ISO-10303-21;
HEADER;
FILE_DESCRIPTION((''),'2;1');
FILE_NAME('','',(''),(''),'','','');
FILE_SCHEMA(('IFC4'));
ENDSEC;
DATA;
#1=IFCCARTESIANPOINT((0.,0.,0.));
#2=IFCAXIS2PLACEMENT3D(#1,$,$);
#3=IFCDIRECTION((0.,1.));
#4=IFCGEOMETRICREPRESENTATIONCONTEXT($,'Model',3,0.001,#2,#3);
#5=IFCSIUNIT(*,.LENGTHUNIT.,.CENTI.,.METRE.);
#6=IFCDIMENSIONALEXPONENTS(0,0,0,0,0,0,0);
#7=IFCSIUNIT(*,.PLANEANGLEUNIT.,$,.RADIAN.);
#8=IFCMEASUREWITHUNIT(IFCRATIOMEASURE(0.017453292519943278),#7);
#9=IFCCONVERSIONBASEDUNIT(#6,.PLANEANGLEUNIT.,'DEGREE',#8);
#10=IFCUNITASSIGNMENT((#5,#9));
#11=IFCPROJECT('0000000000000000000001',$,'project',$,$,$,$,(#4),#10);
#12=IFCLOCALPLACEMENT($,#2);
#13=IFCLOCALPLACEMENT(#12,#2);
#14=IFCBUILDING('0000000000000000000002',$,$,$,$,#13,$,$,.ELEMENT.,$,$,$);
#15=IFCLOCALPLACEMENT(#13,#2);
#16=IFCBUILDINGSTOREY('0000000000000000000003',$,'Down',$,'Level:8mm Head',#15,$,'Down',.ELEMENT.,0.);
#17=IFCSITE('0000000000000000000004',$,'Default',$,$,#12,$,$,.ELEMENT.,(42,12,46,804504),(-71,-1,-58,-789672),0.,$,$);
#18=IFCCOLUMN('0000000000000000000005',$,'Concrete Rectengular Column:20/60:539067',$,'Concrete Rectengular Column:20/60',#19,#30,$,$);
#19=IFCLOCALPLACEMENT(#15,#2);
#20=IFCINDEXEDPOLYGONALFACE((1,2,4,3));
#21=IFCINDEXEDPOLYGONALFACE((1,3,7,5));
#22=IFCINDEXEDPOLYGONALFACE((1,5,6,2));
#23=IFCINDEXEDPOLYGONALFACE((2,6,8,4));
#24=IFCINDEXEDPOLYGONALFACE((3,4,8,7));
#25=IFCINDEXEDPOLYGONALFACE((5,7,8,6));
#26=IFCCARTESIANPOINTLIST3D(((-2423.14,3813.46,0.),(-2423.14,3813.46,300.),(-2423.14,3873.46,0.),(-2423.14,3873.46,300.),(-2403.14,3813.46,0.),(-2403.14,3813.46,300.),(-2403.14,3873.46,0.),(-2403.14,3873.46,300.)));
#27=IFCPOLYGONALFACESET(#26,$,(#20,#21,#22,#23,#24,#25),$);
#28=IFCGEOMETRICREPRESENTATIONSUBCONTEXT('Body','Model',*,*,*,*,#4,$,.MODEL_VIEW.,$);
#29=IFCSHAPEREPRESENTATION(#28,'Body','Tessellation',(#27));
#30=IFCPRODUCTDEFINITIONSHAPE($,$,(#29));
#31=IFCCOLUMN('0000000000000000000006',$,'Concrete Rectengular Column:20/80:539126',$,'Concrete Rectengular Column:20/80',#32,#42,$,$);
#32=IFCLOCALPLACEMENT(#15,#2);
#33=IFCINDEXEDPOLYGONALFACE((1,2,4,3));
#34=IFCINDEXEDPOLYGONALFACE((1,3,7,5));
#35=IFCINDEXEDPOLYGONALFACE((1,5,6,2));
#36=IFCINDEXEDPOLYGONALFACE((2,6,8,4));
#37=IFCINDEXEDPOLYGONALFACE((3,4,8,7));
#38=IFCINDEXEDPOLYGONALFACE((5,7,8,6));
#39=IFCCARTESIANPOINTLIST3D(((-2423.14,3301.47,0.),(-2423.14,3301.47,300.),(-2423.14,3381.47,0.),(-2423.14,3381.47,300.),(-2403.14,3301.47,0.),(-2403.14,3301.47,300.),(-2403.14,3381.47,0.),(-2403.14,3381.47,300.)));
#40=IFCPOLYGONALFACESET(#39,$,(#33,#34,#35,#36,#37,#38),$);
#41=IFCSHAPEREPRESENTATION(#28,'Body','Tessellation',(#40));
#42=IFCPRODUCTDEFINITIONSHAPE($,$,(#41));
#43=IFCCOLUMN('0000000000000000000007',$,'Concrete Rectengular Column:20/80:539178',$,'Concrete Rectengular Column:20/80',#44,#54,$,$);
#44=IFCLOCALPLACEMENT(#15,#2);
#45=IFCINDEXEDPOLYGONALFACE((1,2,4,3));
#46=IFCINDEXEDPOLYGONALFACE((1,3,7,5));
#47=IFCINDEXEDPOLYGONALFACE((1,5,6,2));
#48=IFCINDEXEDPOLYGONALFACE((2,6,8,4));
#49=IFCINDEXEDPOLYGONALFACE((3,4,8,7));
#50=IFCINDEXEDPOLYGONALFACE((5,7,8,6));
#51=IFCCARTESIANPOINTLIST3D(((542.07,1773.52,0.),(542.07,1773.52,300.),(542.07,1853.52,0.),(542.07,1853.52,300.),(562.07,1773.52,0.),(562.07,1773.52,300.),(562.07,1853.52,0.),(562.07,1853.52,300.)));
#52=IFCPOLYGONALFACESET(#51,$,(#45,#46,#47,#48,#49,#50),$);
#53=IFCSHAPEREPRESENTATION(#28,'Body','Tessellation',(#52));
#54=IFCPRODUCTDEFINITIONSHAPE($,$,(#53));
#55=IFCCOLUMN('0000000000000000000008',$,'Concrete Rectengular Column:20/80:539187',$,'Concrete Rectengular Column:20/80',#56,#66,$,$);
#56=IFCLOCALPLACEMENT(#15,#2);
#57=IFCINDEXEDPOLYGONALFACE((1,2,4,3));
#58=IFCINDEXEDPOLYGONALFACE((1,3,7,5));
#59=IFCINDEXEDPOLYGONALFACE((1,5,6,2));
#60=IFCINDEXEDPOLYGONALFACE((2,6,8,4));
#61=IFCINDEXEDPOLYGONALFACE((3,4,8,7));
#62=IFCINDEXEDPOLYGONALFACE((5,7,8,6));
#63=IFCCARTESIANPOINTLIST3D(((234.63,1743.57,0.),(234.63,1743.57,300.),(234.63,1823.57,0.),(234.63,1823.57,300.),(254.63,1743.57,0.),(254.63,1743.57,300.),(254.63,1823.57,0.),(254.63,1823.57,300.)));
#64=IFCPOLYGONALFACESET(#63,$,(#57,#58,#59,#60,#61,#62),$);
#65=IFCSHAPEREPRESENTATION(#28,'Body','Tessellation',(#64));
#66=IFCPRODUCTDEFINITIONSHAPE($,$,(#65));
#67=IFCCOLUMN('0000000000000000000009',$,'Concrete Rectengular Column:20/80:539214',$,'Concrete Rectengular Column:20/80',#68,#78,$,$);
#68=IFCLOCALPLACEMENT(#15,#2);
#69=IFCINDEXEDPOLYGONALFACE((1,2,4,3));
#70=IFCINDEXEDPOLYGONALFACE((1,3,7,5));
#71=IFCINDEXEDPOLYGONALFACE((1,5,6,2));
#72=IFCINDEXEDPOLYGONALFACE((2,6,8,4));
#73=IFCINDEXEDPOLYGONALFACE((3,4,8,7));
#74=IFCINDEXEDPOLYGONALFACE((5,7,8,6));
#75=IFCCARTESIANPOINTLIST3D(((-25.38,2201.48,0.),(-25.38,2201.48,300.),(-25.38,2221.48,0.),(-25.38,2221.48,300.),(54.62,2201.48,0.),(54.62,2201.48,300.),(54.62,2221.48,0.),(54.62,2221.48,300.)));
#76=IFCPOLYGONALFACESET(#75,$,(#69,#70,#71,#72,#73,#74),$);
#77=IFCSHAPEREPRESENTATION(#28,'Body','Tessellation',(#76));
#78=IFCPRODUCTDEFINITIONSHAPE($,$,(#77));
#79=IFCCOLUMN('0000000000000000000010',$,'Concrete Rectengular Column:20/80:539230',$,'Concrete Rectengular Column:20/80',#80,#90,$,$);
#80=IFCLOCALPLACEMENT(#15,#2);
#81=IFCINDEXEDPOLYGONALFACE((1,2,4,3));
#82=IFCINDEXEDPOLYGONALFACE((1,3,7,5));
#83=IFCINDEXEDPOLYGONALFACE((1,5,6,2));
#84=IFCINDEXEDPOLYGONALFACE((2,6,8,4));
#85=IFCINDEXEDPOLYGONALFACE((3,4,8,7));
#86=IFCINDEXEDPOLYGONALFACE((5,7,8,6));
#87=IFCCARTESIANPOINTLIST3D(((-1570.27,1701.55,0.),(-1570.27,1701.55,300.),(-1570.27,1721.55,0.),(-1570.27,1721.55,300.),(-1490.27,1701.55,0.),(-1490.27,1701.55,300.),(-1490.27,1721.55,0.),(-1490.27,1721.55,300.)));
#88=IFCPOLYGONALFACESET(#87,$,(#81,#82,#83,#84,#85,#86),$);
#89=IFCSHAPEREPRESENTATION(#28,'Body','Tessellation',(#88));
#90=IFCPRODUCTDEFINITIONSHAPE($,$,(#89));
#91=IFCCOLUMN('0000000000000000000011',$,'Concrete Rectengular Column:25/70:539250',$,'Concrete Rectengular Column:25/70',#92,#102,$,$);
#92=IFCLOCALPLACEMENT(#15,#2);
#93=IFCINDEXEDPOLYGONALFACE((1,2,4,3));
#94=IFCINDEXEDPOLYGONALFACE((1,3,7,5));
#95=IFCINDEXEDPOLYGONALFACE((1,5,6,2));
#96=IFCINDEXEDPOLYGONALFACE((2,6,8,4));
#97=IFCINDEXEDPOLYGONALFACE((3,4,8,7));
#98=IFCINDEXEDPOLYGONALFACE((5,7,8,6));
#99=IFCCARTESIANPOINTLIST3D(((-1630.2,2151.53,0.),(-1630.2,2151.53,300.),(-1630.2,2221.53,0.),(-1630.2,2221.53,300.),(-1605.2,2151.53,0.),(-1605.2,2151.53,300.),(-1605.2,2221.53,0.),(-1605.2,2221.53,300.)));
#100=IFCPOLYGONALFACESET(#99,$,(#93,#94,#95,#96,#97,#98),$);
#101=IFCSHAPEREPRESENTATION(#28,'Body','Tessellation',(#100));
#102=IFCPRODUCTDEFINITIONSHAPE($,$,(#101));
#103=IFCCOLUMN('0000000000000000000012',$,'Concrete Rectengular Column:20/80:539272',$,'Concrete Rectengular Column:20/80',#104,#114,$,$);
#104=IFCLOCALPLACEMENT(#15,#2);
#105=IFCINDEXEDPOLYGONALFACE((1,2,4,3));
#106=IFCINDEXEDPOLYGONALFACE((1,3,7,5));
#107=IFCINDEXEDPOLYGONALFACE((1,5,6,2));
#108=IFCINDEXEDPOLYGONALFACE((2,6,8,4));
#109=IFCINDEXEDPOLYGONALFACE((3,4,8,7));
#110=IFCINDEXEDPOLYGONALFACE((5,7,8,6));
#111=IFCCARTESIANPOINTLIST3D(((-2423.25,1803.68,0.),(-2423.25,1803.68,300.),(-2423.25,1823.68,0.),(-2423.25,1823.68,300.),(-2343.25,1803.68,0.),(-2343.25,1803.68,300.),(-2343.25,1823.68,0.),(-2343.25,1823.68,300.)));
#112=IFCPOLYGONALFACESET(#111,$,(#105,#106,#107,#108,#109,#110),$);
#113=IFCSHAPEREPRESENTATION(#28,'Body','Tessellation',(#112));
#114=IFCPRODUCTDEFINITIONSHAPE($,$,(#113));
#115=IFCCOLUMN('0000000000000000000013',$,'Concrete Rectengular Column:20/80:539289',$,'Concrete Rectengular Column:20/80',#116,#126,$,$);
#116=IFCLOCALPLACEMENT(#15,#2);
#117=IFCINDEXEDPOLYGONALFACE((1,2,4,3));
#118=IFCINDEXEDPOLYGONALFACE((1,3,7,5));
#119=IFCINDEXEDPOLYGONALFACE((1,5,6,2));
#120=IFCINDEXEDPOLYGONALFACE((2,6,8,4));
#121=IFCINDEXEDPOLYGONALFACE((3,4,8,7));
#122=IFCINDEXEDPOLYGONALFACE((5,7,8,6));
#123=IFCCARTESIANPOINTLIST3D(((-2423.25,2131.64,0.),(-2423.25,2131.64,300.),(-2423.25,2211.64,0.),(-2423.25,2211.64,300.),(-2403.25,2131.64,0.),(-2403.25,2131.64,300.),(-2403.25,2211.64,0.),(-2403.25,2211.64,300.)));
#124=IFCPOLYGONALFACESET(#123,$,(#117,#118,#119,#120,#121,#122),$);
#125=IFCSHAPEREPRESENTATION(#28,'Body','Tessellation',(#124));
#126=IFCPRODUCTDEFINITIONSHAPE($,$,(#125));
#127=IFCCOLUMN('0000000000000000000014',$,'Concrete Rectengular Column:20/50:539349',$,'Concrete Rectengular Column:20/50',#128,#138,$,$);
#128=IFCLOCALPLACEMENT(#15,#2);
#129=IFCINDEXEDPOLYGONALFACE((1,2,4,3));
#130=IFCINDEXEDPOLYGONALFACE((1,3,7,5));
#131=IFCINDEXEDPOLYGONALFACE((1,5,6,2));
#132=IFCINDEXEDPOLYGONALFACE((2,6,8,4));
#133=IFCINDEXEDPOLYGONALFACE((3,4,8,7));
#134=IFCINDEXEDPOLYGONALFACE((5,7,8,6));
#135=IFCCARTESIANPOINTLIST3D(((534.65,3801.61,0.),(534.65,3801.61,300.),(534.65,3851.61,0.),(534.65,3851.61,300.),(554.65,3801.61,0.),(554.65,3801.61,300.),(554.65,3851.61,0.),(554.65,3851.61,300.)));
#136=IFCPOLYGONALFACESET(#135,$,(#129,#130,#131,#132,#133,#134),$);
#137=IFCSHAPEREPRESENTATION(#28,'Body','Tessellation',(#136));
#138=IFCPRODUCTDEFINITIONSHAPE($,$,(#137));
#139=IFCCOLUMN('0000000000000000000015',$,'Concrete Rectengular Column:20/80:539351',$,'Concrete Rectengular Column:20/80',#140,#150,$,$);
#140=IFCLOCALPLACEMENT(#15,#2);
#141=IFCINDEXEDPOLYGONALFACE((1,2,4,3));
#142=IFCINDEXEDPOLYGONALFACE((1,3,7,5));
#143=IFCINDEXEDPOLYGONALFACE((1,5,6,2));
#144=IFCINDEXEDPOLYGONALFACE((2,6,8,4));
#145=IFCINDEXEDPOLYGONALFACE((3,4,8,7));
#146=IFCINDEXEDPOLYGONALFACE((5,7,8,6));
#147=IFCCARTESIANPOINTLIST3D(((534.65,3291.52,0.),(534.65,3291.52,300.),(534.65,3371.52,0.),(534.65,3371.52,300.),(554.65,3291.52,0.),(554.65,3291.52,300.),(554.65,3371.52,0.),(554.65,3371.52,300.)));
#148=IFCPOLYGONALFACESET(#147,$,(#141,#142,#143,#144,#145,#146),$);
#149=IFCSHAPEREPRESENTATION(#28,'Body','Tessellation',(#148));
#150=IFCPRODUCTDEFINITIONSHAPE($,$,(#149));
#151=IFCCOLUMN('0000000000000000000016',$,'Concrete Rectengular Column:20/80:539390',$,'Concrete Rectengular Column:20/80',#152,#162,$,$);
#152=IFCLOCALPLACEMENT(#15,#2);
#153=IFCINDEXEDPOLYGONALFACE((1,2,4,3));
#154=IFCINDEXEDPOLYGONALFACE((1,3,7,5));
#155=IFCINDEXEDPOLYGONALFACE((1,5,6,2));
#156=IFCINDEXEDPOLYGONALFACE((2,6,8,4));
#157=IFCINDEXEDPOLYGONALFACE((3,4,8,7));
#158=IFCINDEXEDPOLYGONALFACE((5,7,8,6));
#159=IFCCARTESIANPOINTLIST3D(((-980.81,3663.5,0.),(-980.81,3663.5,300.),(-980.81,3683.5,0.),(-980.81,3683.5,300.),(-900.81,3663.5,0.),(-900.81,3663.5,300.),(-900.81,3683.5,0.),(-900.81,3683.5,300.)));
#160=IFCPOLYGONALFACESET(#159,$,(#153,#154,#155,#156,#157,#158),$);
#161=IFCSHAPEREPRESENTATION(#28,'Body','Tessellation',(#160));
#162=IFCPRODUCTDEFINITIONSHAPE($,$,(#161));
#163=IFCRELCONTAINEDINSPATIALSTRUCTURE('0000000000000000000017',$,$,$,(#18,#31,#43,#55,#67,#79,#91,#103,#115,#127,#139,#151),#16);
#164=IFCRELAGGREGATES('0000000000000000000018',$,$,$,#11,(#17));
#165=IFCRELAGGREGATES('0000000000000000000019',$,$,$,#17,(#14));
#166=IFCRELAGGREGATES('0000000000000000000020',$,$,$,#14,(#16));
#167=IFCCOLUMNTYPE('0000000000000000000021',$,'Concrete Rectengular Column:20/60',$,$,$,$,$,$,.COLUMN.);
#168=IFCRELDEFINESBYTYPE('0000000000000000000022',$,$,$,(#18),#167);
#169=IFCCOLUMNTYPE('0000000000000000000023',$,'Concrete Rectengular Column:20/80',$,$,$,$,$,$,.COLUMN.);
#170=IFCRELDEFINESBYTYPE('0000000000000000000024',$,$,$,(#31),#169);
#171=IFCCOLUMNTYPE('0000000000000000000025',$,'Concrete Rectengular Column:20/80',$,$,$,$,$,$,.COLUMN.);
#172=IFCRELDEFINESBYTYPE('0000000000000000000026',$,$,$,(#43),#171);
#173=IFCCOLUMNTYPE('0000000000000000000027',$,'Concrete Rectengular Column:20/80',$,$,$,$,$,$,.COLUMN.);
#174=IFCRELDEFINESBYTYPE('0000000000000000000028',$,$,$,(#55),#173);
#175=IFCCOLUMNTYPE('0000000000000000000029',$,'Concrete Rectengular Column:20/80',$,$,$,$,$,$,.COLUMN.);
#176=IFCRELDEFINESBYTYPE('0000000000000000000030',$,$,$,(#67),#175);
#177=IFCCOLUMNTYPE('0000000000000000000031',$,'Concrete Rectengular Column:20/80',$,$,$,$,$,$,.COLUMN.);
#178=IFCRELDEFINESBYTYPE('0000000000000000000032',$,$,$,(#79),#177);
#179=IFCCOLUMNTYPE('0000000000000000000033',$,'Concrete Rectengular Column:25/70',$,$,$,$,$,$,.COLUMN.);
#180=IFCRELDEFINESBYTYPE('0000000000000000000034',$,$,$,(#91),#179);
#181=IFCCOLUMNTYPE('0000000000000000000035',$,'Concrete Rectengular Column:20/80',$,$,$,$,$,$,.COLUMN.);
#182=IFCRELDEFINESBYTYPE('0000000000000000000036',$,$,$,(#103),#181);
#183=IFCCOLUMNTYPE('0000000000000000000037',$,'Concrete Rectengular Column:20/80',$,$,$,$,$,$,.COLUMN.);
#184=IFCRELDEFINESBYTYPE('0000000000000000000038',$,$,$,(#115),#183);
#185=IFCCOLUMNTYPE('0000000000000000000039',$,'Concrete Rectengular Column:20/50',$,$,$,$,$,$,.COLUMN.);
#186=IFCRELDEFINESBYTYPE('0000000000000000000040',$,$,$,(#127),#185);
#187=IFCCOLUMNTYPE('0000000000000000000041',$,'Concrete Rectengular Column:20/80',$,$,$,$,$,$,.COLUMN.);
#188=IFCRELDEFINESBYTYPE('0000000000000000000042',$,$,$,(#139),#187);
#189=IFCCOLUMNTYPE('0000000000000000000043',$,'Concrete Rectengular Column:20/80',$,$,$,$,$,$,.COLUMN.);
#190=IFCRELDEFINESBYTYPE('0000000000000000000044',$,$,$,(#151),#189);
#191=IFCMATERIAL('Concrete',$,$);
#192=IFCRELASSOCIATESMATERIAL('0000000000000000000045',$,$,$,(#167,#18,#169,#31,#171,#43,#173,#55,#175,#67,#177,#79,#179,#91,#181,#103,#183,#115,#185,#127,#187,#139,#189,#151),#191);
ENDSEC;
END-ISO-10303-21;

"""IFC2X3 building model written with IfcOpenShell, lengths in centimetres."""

from ifc_helpers import new_model, entity, si_unit, converted_unit, direction, frame, frame_2d, origin, origin_2d_with_axis, place, context, subcontext, project, spatial, rectangle, extrude, source, transform, mapped, material, type_object, type_shapes, element, save


model = new_model("IFC2X3")

# Units and contexts
model_context = context("Model", 3, precision=0.001, world=origin(), true_north=direction((0.0, 1.0)))
body_context = subcontext(model_context, "Body", "Model", "MODEL_VIEW")
ifc_project = project(units=[si_unit("LENGTHUNIT", "METRE", prefix="CENTI"), converted_unit("PLANEANGLEUNIT", "DEGREE", entity("IfcRatioMeasure", 0.017453292519943278), si_unit("PLANEANGLEUNIT", "RADIAN"), dimensions=[0, 0, 0, 0, 0, 0, 0])], contexts=[model_context])

# Site, building, storey
site_placement = place(None, origin())
site = spatial("IfcSite", under=ifc_project, at=site_placement, Name="Default", CompositionType="ELEMENT", RefLatitude=(42, 12, 46, 804504), RefLongitude=(-71, -1, -58, -789672), RefElevation=0.0)
building_placement = place(site_placement, origin())
building = spatial("IfcBuilding", under=site, at=building_placement, CompositionType="ELEMENT")
storey_placement = place(building_placement, origin())
storey = spatial("IfcBuildingStorey", under=building, at=storey_placement, Name="Down", ObjectType="Level:8mm Head", LongName="Down", CompositionType="ELEMENT", Elevation=0.0)

# Columns
ifc_material = material(Name="Concrete")
column_type_1 = type_object("IfcColumnType", Name="Concrete Rectengular Column:20/60", PredefinedType="COLUMN", material=ifc_material)
shared_shape_1 = source(origin(), body_context, "Body", "SweptSolid", [
    extrude(rectangle(XDim=60.0, YDim=20.0, at=origin_2d_with_axis()), frame((-2413.14, 3843.46, 0.0), z_axis=(0.0, 0.0, 1.0), x_axis=(0.0, -1.0, 0.0)), (0.0, 0.0, 1.0), 300.0),
])
type_shapes(column_type_1, [shared_shape_1])
column_1_placement = place(storey_placement, origin())
element("IfcColumn", 1, at=column_1_placement, inside=storey, type_object=column_type_1, material=ifc_material, Name="Concrete Rectengular Column:20/60:539067", ObjectType="Concrete Rectengular Column:20/60", context=body_context, shape_type="MappedRepresentation", body=[
    mapped(shared_shape_1, transform((0.0, 0.0, 0.0), scale=1.0)),
])
column_type_2 = type_object("IfcColumnType", Name="Concrete Rectengular Column:20/80", PredefinedType="COLUMN", material=ifc_material)
shared_shape_2 = source(origin(), body_context, "Body", "SweptSolid", [
    extrude(rectangle(XDim=80.0, YDim=20.0, at=origin_2d_with_axis()), frame((-2413.14, 3341.47, 0.0), z_axis=(0.0, 0.0, 1.0), x_axis=(0.0, -1.0, 0.0)), (0.0, 0.0, 1.0), 300.0),
])
type_shapes(column_type_2, [shared_shape_2])
column_2_placement = place(storey_placement, origin())
element("IfcColumn", 2, at=column_2_placement, inside=storey, type_object=column_type_2, material=ifc_material, Name="Concrete Rectengular Column:20/80:539126", ObjectType="Concrete Rectengular Column:20/80", context=body_context, shape_type="MappedRepresentation", body=[
    mapped(shared_shape_2, transform((0.0, 0.0, 0.0), scale=1.0)),
])
column_type_3 = type_object("IfcColumnType", Name="Concrete Rectengular Column:20/80", PredefinedType="COLUMN", material=ifc_material)
shared_shape_3 = source(origin(), body_context, "Body", "SweptSolid", [
    extrude(rectangle(XDim=80.0, YDim=20.0, at=origin_2d_with_axis()), frame((552.07, 1813.52, 0.0), z_axis=(0.0, 0.0, 1.0), x_axis=(0.0, -1.0, 0.0)), (0.0, 0.0, 1.0), 300.0),
])
type_shapes(column_type_3, [shared_shape_3])
column_3_placement = place(storey_placement, origin())
element("IfcColumn", 3, at=column_3_placement, inside=storey, type_object=column_type_3, material=ifc_material, Name="Concrete Rectengular Column:20/80:539178", ObjectType="Concrete Rectengular Column:20/80", context=body_context, shape_type="MappedRepresentation", body=[
    mapped(shared_shape_3, transform((0.0, 0.0, 0.0), scale=1.0)),
])
column_type_4 = type_object("IfcColumnType", Name="Concrete Rectengular Column:20/80", PredefinedType="COLUMN", material=ifc_material)
shared_shape_4 = source(origin(), body_context, "Body", "SweptSolid", [
    extrude(rectangle(XDim=80.0, YDim=20.0, at=origin_2d_with_axis()), frame((244.63, 1783.57, 0.0), z_axis=(0.0, 0.0, 1.0), x_axis=(0.0, -1.0, 0.0)), (0.0, 0.0, 1.0), 300.0),
])
type_shapes(column_type_4, [shared_shape_4])
column_4_placement = place(storey_placement, origin())
element("IfcColumn", 4, at=column_4_placement, inside=storey, type_object=column_type_4, material=ifc_material, Name="Concrete Rectengular Column:20/80:539187", ObjectType="Concrete Rectengular Column:20/80", context=body_context, shape_type="MappedRepresentation", body=[
    mapped(shared_shape_4, transform((0.0, 0.0, 0.0), scale=1.0)),
])
column_type_5 = type_object("IfcColumnType", Name="Concrete Rectengular Column:20/80", PredefinedType="COLUMN", material=ifc_material)
shared_shape_5 = source(origin(), body_context, "Body", "SweptSolid", [
    extrude(rectangle(XDim=20.0, YDim=80.0, at=origin_2d_with_axis()), frame((14.62, 2211.48, 0.0), z_axis=(0.0, 0.0, 1.0), x_axis=(0.0, -1.0, 0.0)), (0.0, 0.0, 1.0), 300.0),
])
type_shapes(column_type_5, [shared_shape_5])
column_5_placement = place(storey_placement, origin())
element("IfcColumn", 5, at=column_5_placement, inside=storey, type_object=column_type_5, material=ifc_material, Name="Concrete Rectengular Column:20/80:539214", ObjectType="Concrete Rectengular Column:20/80", context=body_context, shape_type="MappedRepresentation", body=[
    mapped(shared_shape_5, transform((0.0, 0.0, 0.0), scale=1.0)),
])
column_type_6 = type_object("IfcColumnType", Name="Concrete Rectengular Column:20/80", PredefinedType="COLUMN", material=ifc_material)
shared_shape_6 = source(origin(), body_context, "Body", "SweptSolid", [
    extrude(rectangle(XDim=20.0, YDim=80.0, at=frame_2d((0.0, 0.0), x_axis=(1.0, 0.0))), frame((-1530.27, 1711.55, 0.0), z_axis=(0.0, 0.0, 1.0), x_axis=(0.0, -1.0, 0.0)), (0.0, 0.0, 1.0), 300.0),
])
type_shapes(column_type_6, [shared_shape_6])
column_6_placement = place(storey_placement, origin())
element("IfcColumn", 6, at=column_6_placement, inside=storey, type_object=column_type_6, material=ifc_material, Name="Concrete Rectengular Column:20/80:539230", ObjectType="Concrete Rectengular Column:20/80", context=body_context, shape_type="MappedRepresentation", body=[
    mapped(shared_shape_6, transform((0.0, 0.0, 0.0), scale=1.0)),
])
column_type_7 = type_object("IfcColumnType", Name="Concrete Rectengular Column:25/70", PredefinedType="COLUMN", material=ifc_material)
shared_shape_7 = source(origin(), body_context, "Body", "SweptSolid", [
    extrude(rectangle(XDim=70.0, YDim=25.0, at=frame_2d((0.0, 0.0), x_axis=(1.0, 0.0))), frame((-1617.7, 2186.53, 0.0), z_axis=(0.0, 0.0, 1.0), x_axis=(0.0, -1.0, 0.0)), (0.0, 0.0, 1.0), 300.0),
])
type_shapes(column_type_7, [shared_shape_7])
column_7_placement = place(storey_placement, origin())
element("IfcColumn", 7, at=column_7_placement, inside=storey, type_object=column_type_7, material=ifc_material, Name="Concrete Rectengular Column:25/70:539250", ObjectType="Concrete Rectengular Column:25/70", context=body_context, shape_type="MappedRepresentation", body=[
    mapped(shared_shape_7, transform((0.0, 0.0, 0.0), scale=1.0)),
])
column_type_8 = type_object("IfcColumnType", Name="Concrete Rectengular Column:20/80", PredefinedType="COLUMN", material=ifc_material)
shared_shape_8 = source(origin(), body_context, "Body", "SweptSolid", [
    extrude(rectangle(XDim=20.0, YDim=80.0, at=frame_2d((0.0, 0.0), x_axis=(1.0, 0.0))), frame((-2383.25, 1813.68, 0.0), z_axis=(0.0, 0.0, 1.0), x_axis=(0.0, -1.0, 0.0)), (0.0, 0.0, 1.0), 300.0),
])
type_shapes(column_type_8, [shared_shape_8])
column_8_placement = place(storey_placement, origin())
element("IfcColumn", 8, at=column_8_placement, inside=storey, type_object=column_type_8, material=ifc_material, Name="Concrete Rectengular Column:20/80:539272", ObjectType="Concrete Rectengular Column:20/80", context=body_context, shape_type="MappedRepresentation", body=[
    mapped(shared_shape_8, transform((0.0, 0.0, 0.0), scale=1.0)),
])
column_type_9 = type_object("IfcColumnType", Name="Concrete Rectengular Column:20/80", PredefinedType="COLUMN", material=ifc_material)
shared_shape_9 = source(origin(), body_context, "Body", "SweptSolid", [
    extrude(rectangle(XDim=80.0, YDim=20.0, at=origin_2d_with_axis()), frame((-2413.25, 2171.64, 0.0), z_axis=(0.0, 0.0, 1.0), x_axis=(0.0, -1.0, 0.0)), (0.0, 0.0, 1.0), 300.0),
])
type_shapes(column_type_9, [shared_shape_9])
column_9_placement = place(storey_placement, origin())
element("IfcColumn", 9, at=column_9_placement, inside=storey, type_object=column_type_9, material=ifc_material, Name="Concrete Rectengular Column:20/80:539289", ObjectType="Concrete Rectengular Column:20/80", context=body_context, shape_type="MappedRepresentation", body=[
    mapped(shared_shape_9, transform((0.0, 0.0, 0.0), scale=1.0)),
])
column_type_10 = type_object("IfcColumnType", Name="Concrete Rectengular Column:20/50", PredefinedType="COLUMN", material=ifc_material)
shared_shape_10 = source(origin(), body_context, "Body", "SweptSolid", [
    extrude(rectangle(XDim=50.0, YDim=20.0, at=origin_2d_with_axis()), frame((544.65, 3826.61, 0.0), z_axis=(0.0, 0.0, 1.0), x_axis=(0.0, -1.0, 0.0)), (0.0, 0.0, 1.0), 300.0),
])
type_shapes(column_type_10, [shared_shape_10])
column_10_placement = place(storey_placement, origin())
element("IfcColumn", 10, at=column_10_placement, inside=storey, type_object=column_type_10, material=ifc_material, Name="Concrete Rectengular Column:20/50:539349", ObjectType="Concrete Rectengular Column:20/50", context=body_context, shape_type="MappedRepresentation", body=[
    mapped(shared_shape_10, transform((0.0, 0.0, 0.0), scale=1.0)),
])
column_type_11 = type_object("IfcColumnType", Name="Concrete Rectengular Column:20/80", PredefinedType="COLUMN", material=ifc_material)
shared_shape_11 = source(origin(), body_context, "Body", "SweptSolid", [
    extrude(rectangle(XDim=80.0, YDim=20.0, at=origin_2d_with_axis()), frame((544.65, 3331.52, 0.0), z_axis=(0.0, 0.0, 1.0), x_axis=(0.0, -1.0, 0.0)), (0.0, 0.0, 1.0), 300.0),
])
type_shapes(column_type_11, [shared_shape_11])
column_11_placement = place(storey_placement, origin())
element("IfcColumn", 11, at=column_11_placement, inside=storey, type_object=column_type_11, material=ifc_material, Name="Concrete Rectengular Column:20/80:539351", ObjectType="Concrete Rectengular Column:20/80", context=body_context, shape_type="MappedRepresentation", body=[
    mapped(shared_shape_11, transform((0.0, 0.0, 0.0), scale=1.0)),
])
column_type_12 = type_object("IfcColumnType", Name="Concrete Rectengular Column:20/80", PredefinedType="COLUMN", material=ifc_material)
shared_shape_12 = source(origin(), body_context, "Body", "SweptSolid", [
    extrude(rectangle(XDim=20.0, YDim=80.0, at=origin_2d_with_axis()), frame((-940.81, 3673.5, 0.0), z_axis=(0.0, 0.0, 1.0), x_axis=(0.0, -1.0, 0.0)), (0.0, 0.0, 1.0), 300.0),
])
type_shapes(column_type_12, [shared_shape_12])
column_12_placement = place(storey_placement, origin())
element("IfcColumn", 12, at=column_12_placement, inside=storey, type_object=column_type_12, material=ifc_material, Name="Concrete Rectengular Column:20/80:539390", ObjectType="Concrete Rectengular Column:20/80", context=body_context, shape_type="MappedRepresentation", body=[
    mapped(shared_shape_12, transform((0.0, 0.0, 0.0), scale=1.0)),
])

save(model, "model.ifc")
